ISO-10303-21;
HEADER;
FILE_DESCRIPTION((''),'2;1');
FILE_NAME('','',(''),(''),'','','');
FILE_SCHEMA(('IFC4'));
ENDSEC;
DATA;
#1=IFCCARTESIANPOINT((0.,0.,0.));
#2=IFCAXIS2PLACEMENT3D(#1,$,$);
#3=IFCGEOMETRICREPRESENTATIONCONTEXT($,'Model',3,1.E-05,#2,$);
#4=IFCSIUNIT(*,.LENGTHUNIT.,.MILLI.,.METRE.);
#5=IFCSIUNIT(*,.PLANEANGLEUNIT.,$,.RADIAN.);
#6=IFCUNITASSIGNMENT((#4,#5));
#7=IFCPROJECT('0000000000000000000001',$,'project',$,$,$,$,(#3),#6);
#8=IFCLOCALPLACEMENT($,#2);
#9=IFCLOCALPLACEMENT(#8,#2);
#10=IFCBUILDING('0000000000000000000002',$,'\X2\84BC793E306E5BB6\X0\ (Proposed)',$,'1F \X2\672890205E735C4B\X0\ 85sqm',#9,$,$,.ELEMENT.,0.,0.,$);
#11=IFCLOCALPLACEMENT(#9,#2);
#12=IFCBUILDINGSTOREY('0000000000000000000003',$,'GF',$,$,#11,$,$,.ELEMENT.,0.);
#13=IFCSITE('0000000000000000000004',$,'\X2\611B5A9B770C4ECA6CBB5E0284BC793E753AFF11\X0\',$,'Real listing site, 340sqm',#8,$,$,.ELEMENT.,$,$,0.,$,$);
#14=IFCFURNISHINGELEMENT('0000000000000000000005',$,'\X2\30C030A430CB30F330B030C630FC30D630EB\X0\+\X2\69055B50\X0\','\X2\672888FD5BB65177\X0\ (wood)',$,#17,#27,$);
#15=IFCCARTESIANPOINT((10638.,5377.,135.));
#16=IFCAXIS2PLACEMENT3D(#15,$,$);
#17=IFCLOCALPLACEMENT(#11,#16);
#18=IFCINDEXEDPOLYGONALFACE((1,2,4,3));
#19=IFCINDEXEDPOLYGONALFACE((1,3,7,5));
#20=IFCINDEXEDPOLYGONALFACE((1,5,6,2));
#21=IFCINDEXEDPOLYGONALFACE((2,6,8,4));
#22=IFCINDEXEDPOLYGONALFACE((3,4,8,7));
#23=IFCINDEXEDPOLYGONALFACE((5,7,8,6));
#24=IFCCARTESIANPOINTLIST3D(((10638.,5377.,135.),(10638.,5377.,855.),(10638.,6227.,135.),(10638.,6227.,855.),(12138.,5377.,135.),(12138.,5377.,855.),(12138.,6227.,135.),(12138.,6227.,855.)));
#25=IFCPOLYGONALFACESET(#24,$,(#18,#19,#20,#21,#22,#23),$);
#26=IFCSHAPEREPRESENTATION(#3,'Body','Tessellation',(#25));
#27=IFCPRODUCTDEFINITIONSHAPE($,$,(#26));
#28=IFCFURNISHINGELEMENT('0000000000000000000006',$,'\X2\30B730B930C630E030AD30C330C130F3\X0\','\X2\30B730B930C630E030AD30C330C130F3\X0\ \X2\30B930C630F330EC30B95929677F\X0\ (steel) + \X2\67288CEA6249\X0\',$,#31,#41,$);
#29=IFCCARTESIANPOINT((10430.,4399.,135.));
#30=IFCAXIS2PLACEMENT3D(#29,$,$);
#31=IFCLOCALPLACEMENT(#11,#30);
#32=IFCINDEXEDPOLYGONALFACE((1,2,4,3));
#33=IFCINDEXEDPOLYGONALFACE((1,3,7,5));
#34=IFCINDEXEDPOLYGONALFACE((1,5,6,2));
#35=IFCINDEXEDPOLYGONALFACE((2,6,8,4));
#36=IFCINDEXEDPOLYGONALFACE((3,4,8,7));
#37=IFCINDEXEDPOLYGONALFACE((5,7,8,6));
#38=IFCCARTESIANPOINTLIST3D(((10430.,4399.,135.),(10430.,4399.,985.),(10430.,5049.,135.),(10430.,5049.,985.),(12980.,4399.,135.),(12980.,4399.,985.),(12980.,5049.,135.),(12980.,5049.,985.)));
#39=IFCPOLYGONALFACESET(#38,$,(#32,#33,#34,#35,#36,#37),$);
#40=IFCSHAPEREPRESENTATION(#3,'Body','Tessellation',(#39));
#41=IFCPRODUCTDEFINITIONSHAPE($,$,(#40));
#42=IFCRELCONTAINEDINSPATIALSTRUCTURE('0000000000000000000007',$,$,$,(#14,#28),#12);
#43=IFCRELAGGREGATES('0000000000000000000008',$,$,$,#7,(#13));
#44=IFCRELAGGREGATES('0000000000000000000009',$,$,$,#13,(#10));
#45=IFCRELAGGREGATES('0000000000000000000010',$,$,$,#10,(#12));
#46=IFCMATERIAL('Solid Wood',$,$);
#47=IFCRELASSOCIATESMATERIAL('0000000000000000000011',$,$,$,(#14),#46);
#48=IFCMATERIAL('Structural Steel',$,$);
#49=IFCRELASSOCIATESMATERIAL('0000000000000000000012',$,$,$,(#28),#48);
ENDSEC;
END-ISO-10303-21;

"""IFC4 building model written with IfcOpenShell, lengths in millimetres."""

from ifc_helpers import new_model, si_unit, frame, frame_2d, origin, place, context, project, spatial, rectangle, extrude, material, element, save


model = new_model("IFC4")

# Units and contexts
model_context = context("Model", 3, precision=1e-05, world=origin())
ifc_project = project(units=[si_unit("LENGTHUNIT", "METRE", prefix="MILLI"), si_unit("PLANEANGLEUNIT", "RADIAN")], contexts=[model_context])

# Site, building, storey
site_placement = place(None, origin())
site = spatial("IfcSite", under=ifc_project, at=site_placement, Name="愛媛県今治市蒼社町１", ObjectType="Real listing site, 340sqm", CompositionType="ELEMENT", RefElevation=0.0)
building_placement = place(site_placement, origin())
building = spatial("IfcBuilding", under=site, at=building_placement, Name="蒼社の家 (Proposed)", ObjectType="1F 木造平屋 85sqm", CompositionType="ELEMENT", ElevationOfRefHeight=0.0, ElevationOfTerrain=0.0)
storey_placement = place(building_placement, origin())
storey = spatial("IfcBuildingStorey", under=building, at=storey_placement, Name="GF", CompositionType="ELEMENT", Elevation=0.0)

# Shared definitions
ifc_material_1 = material(Name="Solid Wood")

# Shared definitions
ifc_material_2 = material(Name="Structural Steel")

# Furnishing elements
furnishing_1_placement = place(storey_placement, frame((10638.0, 5377.0, 135.0)))
element("IfcFurnishingElement", 1, at=furnishing_1_placement, inside=storey, material=ifc_material_1, Name="ダイニングテーブル+椅子", Description="木製家具 (wood)", context=model_context, shape_type="SweptSolid", body=[
    extrude(rectangle(XDim=1500.0, YDim=850.0, at=frame_2d((750.0, 425.0))), frame((10638.0, 5377.0, 135.0)), (0.0, 0.0, 1.0), 720.0),
])
furnishing_2_placement = place(storey_placement, frame((10430.0, 4399.0, 135.0)))
element("IfcFurnishingElement", 2, at=furnishing_2_placement, inside=storey, material=ifc_material_2, Name="システムキッチン", Description="システムキッチン ステンレス天板 (steel) + 木質扉", context=model_context, shape_type="SweptSolid", body=[
    extrude(rectangle(XDim=2550.0, YDim=650.0, at=frame_2d((1275.0, 325.0))), frame((10430.0, 4399.0, 135.0)), (0.0, 0.0, 1.0), 850.0),
])

save(model, "model.ifc")
